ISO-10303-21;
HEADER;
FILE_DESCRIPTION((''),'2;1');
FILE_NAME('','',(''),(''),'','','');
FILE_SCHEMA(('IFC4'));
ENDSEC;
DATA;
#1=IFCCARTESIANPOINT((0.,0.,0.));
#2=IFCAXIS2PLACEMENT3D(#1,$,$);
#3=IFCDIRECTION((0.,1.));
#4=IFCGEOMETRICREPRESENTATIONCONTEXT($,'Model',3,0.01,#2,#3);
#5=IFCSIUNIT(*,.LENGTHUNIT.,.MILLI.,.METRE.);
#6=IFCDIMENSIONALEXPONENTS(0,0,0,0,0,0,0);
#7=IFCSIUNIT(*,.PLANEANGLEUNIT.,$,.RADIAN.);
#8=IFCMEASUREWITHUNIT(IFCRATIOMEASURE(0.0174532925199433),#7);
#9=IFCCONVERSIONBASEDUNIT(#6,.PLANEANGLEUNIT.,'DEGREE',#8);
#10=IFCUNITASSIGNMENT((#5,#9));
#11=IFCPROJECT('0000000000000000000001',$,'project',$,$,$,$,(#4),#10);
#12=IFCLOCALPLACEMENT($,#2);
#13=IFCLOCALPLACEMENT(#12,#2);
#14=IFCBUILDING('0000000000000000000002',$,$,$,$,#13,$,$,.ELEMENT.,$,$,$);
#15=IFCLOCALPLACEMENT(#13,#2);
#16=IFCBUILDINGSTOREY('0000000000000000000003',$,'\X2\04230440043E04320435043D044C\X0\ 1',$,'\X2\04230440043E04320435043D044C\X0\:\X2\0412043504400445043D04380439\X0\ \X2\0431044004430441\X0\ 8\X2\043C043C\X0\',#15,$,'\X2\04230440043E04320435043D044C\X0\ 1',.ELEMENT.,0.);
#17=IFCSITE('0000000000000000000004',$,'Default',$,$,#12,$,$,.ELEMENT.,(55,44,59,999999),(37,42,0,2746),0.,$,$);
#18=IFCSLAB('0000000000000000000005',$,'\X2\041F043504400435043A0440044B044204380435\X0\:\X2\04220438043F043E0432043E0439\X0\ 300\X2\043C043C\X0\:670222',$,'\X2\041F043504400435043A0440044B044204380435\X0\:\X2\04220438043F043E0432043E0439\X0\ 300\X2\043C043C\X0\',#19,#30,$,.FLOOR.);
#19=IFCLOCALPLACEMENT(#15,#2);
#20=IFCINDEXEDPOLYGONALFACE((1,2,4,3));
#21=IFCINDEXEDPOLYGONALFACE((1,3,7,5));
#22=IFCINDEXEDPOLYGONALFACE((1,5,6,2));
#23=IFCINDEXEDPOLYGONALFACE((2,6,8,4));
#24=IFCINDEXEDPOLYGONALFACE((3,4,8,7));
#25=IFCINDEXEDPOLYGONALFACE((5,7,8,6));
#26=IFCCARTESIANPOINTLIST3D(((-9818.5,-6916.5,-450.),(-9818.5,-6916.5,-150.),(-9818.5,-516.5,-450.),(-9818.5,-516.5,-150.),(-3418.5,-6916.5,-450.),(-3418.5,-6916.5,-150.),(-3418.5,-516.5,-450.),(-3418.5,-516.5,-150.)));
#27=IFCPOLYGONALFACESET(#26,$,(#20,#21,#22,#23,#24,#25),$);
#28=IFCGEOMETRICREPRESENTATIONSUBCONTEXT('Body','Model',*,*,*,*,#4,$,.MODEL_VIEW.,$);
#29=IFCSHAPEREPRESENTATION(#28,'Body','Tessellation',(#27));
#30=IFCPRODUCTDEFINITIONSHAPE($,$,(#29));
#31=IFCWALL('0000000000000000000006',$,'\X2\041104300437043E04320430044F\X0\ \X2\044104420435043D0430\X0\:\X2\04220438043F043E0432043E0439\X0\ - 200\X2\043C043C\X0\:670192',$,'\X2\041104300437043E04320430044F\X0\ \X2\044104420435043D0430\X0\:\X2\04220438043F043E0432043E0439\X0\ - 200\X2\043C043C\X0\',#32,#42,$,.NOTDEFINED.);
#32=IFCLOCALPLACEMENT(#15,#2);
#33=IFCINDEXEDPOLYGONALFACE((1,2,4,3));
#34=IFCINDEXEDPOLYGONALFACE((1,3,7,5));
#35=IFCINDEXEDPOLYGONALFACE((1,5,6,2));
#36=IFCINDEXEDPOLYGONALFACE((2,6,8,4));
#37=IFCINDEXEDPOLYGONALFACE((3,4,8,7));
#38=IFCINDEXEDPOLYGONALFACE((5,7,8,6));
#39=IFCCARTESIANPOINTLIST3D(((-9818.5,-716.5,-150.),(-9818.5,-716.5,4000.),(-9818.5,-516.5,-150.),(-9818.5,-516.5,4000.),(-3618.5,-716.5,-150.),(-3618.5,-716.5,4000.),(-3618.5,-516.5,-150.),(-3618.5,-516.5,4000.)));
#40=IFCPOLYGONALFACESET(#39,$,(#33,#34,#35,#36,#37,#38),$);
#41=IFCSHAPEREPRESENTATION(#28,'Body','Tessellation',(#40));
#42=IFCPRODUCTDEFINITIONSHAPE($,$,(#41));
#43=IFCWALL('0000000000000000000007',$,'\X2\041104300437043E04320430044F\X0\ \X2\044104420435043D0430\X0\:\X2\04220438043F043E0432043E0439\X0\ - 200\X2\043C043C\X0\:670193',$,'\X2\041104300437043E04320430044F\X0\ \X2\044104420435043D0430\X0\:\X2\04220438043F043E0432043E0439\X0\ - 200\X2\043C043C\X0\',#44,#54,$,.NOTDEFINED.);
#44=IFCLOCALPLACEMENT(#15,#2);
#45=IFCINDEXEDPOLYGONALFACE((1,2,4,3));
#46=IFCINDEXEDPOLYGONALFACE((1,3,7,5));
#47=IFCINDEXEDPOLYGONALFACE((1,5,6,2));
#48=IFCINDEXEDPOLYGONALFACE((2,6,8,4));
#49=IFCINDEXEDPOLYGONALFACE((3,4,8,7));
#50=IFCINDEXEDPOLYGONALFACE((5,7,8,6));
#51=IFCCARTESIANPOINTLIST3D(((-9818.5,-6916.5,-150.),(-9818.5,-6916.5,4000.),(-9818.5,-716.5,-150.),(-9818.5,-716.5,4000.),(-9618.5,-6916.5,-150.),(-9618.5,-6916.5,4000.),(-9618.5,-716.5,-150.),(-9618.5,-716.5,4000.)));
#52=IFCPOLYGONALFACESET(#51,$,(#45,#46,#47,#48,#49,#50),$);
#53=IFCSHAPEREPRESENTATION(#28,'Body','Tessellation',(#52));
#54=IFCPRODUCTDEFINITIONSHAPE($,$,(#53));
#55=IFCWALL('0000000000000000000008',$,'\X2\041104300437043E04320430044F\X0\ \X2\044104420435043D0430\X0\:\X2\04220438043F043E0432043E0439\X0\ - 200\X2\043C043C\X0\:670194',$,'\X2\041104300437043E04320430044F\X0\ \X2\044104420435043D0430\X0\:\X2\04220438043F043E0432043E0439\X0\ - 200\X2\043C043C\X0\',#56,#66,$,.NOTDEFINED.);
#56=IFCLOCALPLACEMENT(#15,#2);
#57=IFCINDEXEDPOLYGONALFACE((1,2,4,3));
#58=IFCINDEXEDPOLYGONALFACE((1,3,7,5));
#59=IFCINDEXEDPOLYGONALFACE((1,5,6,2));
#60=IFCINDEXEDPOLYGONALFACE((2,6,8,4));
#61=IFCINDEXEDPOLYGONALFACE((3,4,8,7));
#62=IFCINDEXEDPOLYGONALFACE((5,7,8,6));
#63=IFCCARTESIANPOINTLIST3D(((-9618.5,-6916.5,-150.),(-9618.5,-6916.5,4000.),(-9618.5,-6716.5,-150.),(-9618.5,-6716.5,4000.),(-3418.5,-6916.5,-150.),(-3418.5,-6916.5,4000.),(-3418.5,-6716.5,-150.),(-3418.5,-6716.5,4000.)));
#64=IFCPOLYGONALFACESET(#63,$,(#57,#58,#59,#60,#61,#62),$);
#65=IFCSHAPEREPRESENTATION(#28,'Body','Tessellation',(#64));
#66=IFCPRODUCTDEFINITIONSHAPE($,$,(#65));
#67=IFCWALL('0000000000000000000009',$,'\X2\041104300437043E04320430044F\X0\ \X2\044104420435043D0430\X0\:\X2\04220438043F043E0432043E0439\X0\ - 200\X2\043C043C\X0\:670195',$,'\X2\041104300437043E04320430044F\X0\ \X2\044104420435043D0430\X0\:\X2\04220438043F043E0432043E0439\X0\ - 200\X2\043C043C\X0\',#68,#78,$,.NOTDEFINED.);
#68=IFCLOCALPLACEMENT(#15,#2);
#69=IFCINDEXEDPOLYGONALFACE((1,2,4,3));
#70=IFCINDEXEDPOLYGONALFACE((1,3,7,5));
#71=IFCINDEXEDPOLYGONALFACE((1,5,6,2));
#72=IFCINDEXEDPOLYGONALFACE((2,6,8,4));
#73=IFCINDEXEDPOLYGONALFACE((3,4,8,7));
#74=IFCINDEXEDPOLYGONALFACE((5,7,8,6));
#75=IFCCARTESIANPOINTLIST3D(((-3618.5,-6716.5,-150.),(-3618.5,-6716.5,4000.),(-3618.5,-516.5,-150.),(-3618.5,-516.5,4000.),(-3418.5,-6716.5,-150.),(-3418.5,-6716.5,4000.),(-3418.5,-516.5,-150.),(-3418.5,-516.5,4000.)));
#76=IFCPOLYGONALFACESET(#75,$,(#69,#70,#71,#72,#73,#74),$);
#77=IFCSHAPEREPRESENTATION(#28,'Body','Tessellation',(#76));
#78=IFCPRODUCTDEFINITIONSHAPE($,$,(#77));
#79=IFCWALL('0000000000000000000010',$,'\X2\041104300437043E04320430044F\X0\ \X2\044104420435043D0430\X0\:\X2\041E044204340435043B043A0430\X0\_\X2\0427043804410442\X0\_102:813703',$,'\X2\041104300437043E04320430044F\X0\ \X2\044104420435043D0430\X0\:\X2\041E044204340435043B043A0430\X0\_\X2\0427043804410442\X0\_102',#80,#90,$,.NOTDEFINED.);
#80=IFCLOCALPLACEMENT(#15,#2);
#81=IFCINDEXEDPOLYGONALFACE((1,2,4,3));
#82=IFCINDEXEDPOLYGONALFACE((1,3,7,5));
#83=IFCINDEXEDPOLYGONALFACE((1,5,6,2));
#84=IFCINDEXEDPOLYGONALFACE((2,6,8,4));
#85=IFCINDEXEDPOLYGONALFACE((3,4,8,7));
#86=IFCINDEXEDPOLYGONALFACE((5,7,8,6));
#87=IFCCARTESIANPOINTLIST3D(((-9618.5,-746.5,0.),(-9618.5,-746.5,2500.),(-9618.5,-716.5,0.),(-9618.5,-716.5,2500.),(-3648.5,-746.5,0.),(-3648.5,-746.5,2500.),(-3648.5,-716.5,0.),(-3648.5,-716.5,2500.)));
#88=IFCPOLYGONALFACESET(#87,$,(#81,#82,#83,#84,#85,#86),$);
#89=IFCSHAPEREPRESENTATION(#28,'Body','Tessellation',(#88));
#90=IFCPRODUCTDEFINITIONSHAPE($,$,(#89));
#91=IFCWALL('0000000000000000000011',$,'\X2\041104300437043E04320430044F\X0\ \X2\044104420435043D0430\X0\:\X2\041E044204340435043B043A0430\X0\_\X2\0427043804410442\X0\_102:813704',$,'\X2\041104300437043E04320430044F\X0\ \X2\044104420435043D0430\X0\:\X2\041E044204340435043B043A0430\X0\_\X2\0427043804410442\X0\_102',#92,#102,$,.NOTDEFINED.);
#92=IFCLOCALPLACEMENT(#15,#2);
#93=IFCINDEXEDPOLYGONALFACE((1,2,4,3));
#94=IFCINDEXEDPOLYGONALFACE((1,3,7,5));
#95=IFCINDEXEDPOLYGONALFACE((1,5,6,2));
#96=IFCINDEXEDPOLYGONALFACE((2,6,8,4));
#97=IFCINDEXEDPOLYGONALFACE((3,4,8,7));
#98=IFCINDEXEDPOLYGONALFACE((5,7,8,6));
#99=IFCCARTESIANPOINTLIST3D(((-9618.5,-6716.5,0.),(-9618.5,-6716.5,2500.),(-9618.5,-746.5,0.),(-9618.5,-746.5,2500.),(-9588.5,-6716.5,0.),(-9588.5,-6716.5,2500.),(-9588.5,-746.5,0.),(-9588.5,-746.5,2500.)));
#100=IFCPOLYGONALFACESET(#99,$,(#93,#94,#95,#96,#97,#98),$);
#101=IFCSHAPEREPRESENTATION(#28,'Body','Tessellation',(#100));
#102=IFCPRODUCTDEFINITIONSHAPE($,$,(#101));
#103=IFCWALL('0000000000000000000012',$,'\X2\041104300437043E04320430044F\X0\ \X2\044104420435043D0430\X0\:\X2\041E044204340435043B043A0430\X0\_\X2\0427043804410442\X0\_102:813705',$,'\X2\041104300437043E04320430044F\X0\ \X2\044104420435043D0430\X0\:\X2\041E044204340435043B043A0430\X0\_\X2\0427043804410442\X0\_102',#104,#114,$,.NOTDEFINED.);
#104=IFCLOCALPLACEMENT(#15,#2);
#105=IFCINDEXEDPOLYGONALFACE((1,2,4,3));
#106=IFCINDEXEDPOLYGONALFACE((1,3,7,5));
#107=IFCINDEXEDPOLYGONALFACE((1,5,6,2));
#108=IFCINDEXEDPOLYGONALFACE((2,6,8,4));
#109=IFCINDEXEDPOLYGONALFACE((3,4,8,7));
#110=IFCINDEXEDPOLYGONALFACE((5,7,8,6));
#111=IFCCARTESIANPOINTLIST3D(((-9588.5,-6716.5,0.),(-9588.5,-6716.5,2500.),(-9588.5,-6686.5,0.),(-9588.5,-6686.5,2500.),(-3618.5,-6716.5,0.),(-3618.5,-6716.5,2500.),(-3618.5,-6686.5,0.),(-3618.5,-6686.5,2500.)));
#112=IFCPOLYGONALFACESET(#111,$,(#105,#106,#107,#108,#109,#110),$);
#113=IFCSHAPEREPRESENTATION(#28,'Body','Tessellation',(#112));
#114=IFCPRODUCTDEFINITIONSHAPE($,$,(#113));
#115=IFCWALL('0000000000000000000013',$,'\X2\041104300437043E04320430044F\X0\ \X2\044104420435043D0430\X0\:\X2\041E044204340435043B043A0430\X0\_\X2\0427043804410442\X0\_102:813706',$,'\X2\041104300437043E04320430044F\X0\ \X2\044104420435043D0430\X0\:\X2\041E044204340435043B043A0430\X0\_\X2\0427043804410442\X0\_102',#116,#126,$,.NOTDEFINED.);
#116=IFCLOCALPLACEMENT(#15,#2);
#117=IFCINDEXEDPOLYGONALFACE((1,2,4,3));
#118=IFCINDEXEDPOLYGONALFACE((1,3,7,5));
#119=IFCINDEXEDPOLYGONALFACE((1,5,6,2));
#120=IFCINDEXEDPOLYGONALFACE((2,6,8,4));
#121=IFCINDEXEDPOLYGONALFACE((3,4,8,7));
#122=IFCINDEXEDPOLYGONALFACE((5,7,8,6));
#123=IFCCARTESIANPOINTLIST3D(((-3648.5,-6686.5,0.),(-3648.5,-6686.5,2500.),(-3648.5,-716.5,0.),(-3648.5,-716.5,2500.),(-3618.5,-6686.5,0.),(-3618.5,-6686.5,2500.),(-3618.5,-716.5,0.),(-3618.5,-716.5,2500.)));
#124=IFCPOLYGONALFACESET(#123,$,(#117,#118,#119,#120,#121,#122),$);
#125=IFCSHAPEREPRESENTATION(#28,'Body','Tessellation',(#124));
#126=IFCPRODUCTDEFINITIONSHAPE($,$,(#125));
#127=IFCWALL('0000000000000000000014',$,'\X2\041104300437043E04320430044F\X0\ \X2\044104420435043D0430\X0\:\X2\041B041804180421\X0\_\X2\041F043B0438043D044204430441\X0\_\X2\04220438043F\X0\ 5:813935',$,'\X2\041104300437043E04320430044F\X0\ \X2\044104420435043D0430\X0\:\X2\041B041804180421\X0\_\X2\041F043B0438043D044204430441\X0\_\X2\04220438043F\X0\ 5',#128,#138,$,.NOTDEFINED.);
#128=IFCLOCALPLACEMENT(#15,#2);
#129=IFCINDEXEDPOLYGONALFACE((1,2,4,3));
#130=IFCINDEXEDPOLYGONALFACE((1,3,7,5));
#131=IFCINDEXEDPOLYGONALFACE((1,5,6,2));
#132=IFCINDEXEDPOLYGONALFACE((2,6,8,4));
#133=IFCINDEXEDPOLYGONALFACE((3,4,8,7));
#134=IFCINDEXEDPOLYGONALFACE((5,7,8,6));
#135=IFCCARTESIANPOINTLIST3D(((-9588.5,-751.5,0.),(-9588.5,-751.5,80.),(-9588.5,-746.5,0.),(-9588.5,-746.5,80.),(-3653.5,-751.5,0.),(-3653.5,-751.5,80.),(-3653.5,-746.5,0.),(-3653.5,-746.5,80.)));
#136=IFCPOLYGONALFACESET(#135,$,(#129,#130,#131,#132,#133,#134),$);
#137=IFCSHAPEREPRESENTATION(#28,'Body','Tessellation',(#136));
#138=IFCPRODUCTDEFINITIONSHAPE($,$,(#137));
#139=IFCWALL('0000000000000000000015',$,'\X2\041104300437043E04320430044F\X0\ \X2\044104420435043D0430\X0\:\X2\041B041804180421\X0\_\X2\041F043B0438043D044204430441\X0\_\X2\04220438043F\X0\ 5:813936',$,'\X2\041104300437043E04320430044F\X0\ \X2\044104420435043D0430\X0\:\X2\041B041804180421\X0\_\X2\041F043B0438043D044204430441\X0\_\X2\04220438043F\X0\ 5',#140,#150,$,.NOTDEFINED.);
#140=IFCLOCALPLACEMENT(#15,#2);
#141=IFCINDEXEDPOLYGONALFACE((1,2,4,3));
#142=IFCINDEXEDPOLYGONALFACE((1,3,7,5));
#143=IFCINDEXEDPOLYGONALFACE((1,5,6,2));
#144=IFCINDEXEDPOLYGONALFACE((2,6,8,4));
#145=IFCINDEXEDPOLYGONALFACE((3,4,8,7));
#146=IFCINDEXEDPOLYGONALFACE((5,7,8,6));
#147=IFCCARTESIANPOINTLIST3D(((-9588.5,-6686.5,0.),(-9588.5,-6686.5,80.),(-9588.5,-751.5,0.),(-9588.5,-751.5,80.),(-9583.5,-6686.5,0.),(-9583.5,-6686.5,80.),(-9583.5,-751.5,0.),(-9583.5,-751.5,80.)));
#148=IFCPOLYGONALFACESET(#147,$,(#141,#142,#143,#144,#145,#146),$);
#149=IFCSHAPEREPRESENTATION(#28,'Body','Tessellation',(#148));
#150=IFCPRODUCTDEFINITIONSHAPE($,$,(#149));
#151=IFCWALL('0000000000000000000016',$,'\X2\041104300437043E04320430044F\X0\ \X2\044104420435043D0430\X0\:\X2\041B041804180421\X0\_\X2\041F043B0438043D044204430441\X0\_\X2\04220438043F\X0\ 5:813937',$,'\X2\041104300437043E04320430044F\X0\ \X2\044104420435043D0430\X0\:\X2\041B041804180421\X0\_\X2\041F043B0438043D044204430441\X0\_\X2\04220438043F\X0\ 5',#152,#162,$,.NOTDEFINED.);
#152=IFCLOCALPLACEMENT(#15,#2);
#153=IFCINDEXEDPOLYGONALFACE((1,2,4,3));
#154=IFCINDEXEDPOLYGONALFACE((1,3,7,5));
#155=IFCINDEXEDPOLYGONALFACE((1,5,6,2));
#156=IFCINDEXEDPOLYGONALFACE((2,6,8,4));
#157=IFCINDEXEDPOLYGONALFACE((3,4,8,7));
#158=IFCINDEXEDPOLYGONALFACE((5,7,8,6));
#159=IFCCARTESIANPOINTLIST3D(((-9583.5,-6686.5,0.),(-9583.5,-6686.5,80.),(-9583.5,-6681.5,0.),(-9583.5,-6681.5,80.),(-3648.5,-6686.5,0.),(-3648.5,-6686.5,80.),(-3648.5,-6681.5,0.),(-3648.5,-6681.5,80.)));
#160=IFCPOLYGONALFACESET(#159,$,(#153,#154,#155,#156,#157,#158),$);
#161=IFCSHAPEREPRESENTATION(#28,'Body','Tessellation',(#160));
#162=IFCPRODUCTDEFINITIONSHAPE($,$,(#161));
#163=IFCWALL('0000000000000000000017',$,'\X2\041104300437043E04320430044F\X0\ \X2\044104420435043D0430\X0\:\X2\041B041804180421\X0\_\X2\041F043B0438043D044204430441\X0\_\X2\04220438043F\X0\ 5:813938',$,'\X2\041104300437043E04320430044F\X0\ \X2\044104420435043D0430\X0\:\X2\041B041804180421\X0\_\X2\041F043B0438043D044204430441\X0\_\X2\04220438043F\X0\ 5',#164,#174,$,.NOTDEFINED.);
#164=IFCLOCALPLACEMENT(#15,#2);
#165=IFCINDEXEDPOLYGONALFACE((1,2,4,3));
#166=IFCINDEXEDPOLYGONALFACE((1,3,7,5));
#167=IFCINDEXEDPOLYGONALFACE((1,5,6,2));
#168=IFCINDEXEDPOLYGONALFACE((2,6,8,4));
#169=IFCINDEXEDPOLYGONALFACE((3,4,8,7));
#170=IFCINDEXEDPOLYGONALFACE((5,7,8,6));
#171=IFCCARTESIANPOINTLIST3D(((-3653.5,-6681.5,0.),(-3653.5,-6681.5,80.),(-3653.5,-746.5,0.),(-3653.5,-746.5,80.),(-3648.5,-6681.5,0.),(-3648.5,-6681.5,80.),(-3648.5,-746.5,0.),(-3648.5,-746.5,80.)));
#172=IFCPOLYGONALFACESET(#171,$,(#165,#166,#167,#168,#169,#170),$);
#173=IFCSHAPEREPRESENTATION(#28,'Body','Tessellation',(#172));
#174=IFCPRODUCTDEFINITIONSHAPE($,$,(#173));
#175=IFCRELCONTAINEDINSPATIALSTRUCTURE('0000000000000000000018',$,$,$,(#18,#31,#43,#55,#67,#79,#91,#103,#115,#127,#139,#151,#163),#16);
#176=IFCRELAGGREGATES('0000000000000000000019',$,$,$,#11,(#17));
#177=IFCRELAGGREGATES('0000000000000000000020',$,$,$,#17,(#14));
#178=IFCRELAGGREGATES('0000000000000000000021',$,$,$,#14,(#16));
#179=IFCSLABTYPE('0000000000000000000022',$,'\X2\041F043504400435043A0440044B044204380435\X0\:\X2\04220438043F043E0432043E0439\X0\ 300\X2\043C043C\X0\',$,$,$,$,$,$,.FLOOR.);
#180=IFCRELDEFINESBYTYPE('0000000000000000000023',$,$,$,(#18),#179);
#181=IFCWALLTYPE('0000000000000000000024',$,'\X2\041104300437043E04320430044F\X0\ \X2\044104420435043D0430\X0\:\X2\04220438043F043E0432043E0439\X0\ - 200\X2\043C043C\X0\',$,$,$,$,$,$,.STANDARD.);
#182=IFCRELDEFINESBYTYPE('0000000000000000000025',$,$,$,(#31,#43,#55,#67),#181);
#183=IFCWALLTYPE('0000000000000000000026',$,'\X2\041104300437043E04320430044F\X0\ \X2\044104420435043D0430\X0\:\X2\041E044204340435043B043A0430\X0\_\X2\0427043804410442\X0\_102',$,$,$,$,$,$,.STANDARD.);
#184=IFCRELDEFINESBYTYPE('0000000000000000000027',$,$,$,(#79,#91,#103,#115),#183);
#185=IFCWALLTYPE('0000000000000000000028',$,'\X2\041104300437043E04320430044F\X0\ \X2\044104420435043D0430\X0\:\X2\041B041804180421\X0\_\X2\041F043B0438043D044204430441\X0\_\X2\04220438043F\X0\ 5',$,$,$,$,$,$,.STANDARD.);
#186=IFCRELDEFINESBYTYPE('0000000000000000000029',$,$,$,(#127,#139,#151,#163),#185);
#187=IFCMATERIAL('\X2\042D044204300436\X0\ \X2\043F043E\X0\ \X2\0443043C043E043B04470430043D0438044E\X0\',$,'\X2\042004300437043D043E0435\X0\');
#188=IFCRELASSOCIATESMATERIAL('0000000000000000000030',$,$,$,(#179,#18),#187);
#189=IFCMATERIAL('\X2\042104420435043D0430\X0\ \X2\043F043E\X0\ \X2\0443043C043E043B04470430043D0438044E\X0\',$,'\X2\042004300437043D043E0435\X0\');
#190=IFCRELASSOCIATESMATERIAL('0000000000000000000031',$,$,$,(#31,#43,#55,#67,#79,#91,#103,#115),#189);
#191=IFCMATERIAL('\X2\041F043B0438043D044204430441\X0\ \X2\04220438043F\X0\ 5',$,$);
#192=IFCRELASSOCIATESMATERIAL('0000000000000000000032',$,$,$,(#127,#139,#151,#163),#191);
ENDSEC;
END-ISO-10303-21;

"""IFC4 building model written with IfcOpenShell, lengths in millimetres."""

from ifc_helpers import new_model, entity, si_unit, converted_unit, direction, frame, origin, place, context, subcontext, project, spatial, indexed_curve, outline, extrude, material, type_object, element, save


model = new_model("IFC4")

# Units and contexts
model_context = context("Model", 3, precision=0.01, world=origin(), true_north=direction((0.0, 1.0)))
body_context = subcontext(model_context, "Body", "Model", "MODEL_VIEW")
ifc_project = project(units=[si_unit("LENGTHUNIT", "METRE", prefix="MILLI"), converted_unit("PLANEANGLEUNIT", "DEGREE", entity("IfcRatioMeasure", 0.0174532925199433), si_unit("PLANEANGLEUNIT", "RADIAN"), dimensions=[0, 0, 0, 0, 0, 0, 0])], contexts=[model_context])

# Site, building, storey
site_placement = place(None, origin())
site = spatial("IfcSite", under=ifc_project, at=site_placement, Name="Default", CompositionType="ELEMENT", RefLatitude=(55, 44, 59, 999999), RefLongitude=(37, 42, 0, 2746), RefElevation=0.0)
building_placement = place(site_placement, origin())
building = spatial("IfcBuilding", under=site, at=building_placement, CompositionType="ELEMENT")
storey_placement = place(building_placement, origin())
storey = spatial("IfcBuildingStorey", under=building, at=storey_placement, Name="Уровень 1", ObjectType="Уровень:Верхний брус 8мм", LongName="Уровень 1", CompositionType="ELEMENT", Elevation=0.0)

# Slab
ifc_material_1 = material(Name="Этаж по умолчанию", Category="Разное")
slab_type = type_object("IfcSlabType", Name="Перекрытие:Типовой 300мм", PredefinedType="FLOOR", material=ifc_material_1)
slab_placement = place(storey_placement, origin())
element("IfcSlab", 1, at=slab_placement, inside=storey, type_object=slab_type, material=ifc_material_1, Name="Перекрытие:Типовой 300мм:670222", ObjectType="Перекрытие:Типовой 300мм", PredefinedType="FLOOR", context=body_context, shape_type="SweptSolid", body=[
    extrude(outline(indexed_curve([(-3200.0, -3200.0), (3200.0, -3200.0), (3200.0, 3200.0), (-3200.0, 3200.0), (-3200.0, -3200.0)], self_intersect=False)), frame((-6618.5, -3716.5, -150.0), z_axis=(0.0, 0.0, -1.0), x_axis=(0.0, 1.0, 0.0)), (0.0, 0.0, 1.0), 300.0),
])

# Walls
ifc_material_2 = material(Name="Стена по умолчанию", Category="Разное")
wall_type_1 = type_object("IfcWallType", Name="Базовая стена:Типовой - 200мм", PredefinedType="STANDARD")
wall_1_placement = place(storey_placement, frame((-9818.5, -616.5, -150.0)))
element("IfcWall", 2, at=wall_1_placement, inside=storey, type_object=wall_type_1, material=ifc_material_2, Name="Базовая стена:Типовой - 200мм:670192", ObjectType="Базовая стена:Типовой - 200мм", PredefinedType="NOTDEFINED", context=body_context, shape_type="SweptSolid", body=[
    extrude(outline(indexed_curve([(6200.0, 100.0), (0.0, 100.0), (0.0, -100.0), (6200.0, -100.0), (6200.0, 100.0)], self_intersect=False)), origin(), (0.0, 0.0, 1.0), 4150.0),
])
wall_2_placement = place(storey_placement, frame((-9718.5, -6916.5, -150.0), z_axis=(0.0, 0.0, 1.0), x_axis=(0.0, 1.0, 0.0)))
element("IfcWall", 3, at=wall_2_placement, inside=storey, type_object=wall_type_1, material=ifc_material_2, Name="Базовая стена:Типовой - 200мм:670193", ObjectType="Базовая стена:Типовой - 200мм", PredefinedType="NOTDEFINED", context=body_context, shape_type="SweptSolid", body=[
    extrude(outline(indexed_curve([(6200.0, 100.0), (0.0, 100.0), (0.0, -100.0), (6200.0, -100.0), (6200.0, 100.0)], self_intersect=False)), origin(), (0.0, 0.0, 1.0), 4150.0),
])
for number, where, z_axis, x_axis, name in (
    (4, (-3418.5, -6816.5, -150.0), (0.0, 0.0, 1.0), (-1.0, 0.0, 0.0), "Базовая стена:Типовой - 200мм:670194"),
    (5, (-3518.5, -516.5, -150.0), (0.0, 0.0, 1.0), (0.0, -1.0, 0.0), "Базовая стена:Типовой - 200мм:670195"),
):
    element("IfcWall", number, at=place(storey_placement, frame(where, z_axis=z_axis, x_axis=x_axis)), inside=storey, type_object=wall_type_1, material=ifc_material_2, Name=name, ObjectType="Базовая стена:Типовой - 200мм", PredefinedType="NOTDEFINED", context=body_context, shape_type="SweptSolid", body=[
        extrude(outline(indexed_curve([(6200.0, 100.0), (0.0, 100.0), (0.0, -100.0), (6200.0, -100.0), (6200.0, 100.0)], self_intersect=False)), origin(), (0.0, 0.0, 1.0), 4150.0),
    ])
wall_type_2 = type_object("IfcWallType", Name="Базовая стена:Отделка_Чист_102", PredefinedType="STANDARD")
wall_3_placement = place(storey_placement, frame((-9618.5, -731.5, 0.0)))
element("IfcWall", 6, at=wall_3_placement, inside=storey, type_object=wall_type_2, material=ifc_material_2, Name="Базовая стена:Отделка_Чист_102:813703", ObjectType="Базовая стена:Отделка_Чист_102", PredefinedType="NOTDEFINED", context=body_context, shape_type="SweptSolid", body=[
    extrude(outline(indexed_curve([(5970.0, 15.0), (0.0, 15.0), (0.0, -15.0), (5970.0, -15.0), (5970.0, 15.0)], self_intersect=False)), origin(), (0.0, 0.0, 1.0), 2500.0),
])
for number, where, z_axis, x_axis, name in (
    (7, (-9603.5, -6716.5, 0.0), (0.0, 0.0, 1.0), (0.0, 1.0, 0.0), "Базовая стена:Отделка_Чист_102:813704"),
    (8, (-3618.5, -6701.5, 0.0), (0.0, 0.0, 1.0), (-1.0, 0.0, 0.0), "Базовая стена:Отделка_Чист_102:813705"),
    (9, (-3633.5, -716.5, 0.0), (0.0, 0.0, 1.0), (0.0, -1.0, 0.0), "Базовая стена:Отделка_Чист_102:813706"),
):
    element("IfcWall", number, at=place(storey_placement, frame(where, z_axis=z_axis, x_axis=x_axis)), inside=storey, type_object=wall_type_2, material=ifc_material_2, Name=name, ObjectType="Базовая стена:Отделка_Чист_102", PredefinedType="NOTDEFINED", context=body_context, shape_type="SweptSolid", body=[
        extrude(outline(indexed_curve([(5970.0, 15.0), (0.0, 15.0), (0.0, -15.0), (5970.0, -15.0), (5970.0, 15.0)], self_intersect=False)), origin(), (0.0, 0.0, 1.0), 2500.0),
    ])
ifc_material_3 = material(Name="Плинтус Тип 5")
wall_type_3 = type_object("IfcWallType", Name="Базовая стена:ЛИИС_Плинтус_Тип 5", PredefinedType="STANDARD")
wall_4_placement = place(storey_placement, frame((-9588.5, -749.0, 0.0)))
element("IfcWall", 10, at=wall_4_placement, inside=storey, type_object=wall_type_3, material=ifc_material_3, Name="Базовая стена:ЛИИС_Плинтус_Тип 5:813935", ObjectType="Базовая стена:ЛИИС_Плинтус_Тип 5", PredefinedType="NOTDEFINED", context=body_context, shape_type="SweptSolid", body=[
    extrude(outline(indexed_curve([(5935.0, 2.5), (0.0, 2.5), (0.0, -2.5), (5935.0, -2.5), (5935.0, 2.5)], self_intersect=False)), origin(), (0.0, 0.0, 1.0), 80.0),
])
for number, where, z_axis, x_axis, name in (
    (11, (-9586.0, -6686.5, 0.0), (0.0, 0.0, 1.0), (0.0, 1.0, 0.0), "Базовая стена:ЛИИС_Плинтус_Тип 5:813936"),
    (12, (-3648.5, -6684.0, 0.0), (0.0, 0.0, 1.0), (-1.0, 0.0, 0.0), "Базовая стена:ЛИИС_Плинтус_Тип 5:813937"),
):
    element("IfcWall", number, at=place(storey_placement, frame(where, z_axis=z_axis, x_axis=x_axis)), inside=storey, type_object=wall_type_3, material=ifc_material_3, Name=name, ObjectType="Базовая стена:ЛИИС_Плинтус_Тип 5", PredefinedType="NOTDEFINED", context=body_context, shape_type="SweptSolid", body=[
        extrude(outline(indexed_curve([(5935.0, 2.5), (0.0, 2.5), (0.0, -2.5), (5935.0, -2.5), (5935.0, 2.5)], self_intersect=False)), origin(), (0.0, 0.0, 1.0), 80.0),
    ])
wall_5_placement = place(storey_placement, frame((-3651.0, -746.5, 0.0), z_axis=(0.0, 0.0, 1.0), x_axis=(0.0, -1.0, 0.0)))
element("IfcWall", 13, at=wall_5_placement, inside=storey, type_object=wall_type_3, material=ifc_material_3, Name="Базовая стена:ЛИИС_Плинтус_Тип 5:813938", ObjectType="Базовая стена:ЛИИС_Плинтус_Тип 5", PredefinedType="NOTDEFINED", context=body_context, shape_type="SweptSolid", body=[
    extrude(outline(indexed_curve([(5935.0, 2.5), (0.0, 2.5), (0.0, -2.5), (5935.0, -2.5), (5935.0, 2.5)], self_intersect=False)), origin(), (0.0, 0.0, 1.0), 80.0),
])

save(model, "model.ifc")
